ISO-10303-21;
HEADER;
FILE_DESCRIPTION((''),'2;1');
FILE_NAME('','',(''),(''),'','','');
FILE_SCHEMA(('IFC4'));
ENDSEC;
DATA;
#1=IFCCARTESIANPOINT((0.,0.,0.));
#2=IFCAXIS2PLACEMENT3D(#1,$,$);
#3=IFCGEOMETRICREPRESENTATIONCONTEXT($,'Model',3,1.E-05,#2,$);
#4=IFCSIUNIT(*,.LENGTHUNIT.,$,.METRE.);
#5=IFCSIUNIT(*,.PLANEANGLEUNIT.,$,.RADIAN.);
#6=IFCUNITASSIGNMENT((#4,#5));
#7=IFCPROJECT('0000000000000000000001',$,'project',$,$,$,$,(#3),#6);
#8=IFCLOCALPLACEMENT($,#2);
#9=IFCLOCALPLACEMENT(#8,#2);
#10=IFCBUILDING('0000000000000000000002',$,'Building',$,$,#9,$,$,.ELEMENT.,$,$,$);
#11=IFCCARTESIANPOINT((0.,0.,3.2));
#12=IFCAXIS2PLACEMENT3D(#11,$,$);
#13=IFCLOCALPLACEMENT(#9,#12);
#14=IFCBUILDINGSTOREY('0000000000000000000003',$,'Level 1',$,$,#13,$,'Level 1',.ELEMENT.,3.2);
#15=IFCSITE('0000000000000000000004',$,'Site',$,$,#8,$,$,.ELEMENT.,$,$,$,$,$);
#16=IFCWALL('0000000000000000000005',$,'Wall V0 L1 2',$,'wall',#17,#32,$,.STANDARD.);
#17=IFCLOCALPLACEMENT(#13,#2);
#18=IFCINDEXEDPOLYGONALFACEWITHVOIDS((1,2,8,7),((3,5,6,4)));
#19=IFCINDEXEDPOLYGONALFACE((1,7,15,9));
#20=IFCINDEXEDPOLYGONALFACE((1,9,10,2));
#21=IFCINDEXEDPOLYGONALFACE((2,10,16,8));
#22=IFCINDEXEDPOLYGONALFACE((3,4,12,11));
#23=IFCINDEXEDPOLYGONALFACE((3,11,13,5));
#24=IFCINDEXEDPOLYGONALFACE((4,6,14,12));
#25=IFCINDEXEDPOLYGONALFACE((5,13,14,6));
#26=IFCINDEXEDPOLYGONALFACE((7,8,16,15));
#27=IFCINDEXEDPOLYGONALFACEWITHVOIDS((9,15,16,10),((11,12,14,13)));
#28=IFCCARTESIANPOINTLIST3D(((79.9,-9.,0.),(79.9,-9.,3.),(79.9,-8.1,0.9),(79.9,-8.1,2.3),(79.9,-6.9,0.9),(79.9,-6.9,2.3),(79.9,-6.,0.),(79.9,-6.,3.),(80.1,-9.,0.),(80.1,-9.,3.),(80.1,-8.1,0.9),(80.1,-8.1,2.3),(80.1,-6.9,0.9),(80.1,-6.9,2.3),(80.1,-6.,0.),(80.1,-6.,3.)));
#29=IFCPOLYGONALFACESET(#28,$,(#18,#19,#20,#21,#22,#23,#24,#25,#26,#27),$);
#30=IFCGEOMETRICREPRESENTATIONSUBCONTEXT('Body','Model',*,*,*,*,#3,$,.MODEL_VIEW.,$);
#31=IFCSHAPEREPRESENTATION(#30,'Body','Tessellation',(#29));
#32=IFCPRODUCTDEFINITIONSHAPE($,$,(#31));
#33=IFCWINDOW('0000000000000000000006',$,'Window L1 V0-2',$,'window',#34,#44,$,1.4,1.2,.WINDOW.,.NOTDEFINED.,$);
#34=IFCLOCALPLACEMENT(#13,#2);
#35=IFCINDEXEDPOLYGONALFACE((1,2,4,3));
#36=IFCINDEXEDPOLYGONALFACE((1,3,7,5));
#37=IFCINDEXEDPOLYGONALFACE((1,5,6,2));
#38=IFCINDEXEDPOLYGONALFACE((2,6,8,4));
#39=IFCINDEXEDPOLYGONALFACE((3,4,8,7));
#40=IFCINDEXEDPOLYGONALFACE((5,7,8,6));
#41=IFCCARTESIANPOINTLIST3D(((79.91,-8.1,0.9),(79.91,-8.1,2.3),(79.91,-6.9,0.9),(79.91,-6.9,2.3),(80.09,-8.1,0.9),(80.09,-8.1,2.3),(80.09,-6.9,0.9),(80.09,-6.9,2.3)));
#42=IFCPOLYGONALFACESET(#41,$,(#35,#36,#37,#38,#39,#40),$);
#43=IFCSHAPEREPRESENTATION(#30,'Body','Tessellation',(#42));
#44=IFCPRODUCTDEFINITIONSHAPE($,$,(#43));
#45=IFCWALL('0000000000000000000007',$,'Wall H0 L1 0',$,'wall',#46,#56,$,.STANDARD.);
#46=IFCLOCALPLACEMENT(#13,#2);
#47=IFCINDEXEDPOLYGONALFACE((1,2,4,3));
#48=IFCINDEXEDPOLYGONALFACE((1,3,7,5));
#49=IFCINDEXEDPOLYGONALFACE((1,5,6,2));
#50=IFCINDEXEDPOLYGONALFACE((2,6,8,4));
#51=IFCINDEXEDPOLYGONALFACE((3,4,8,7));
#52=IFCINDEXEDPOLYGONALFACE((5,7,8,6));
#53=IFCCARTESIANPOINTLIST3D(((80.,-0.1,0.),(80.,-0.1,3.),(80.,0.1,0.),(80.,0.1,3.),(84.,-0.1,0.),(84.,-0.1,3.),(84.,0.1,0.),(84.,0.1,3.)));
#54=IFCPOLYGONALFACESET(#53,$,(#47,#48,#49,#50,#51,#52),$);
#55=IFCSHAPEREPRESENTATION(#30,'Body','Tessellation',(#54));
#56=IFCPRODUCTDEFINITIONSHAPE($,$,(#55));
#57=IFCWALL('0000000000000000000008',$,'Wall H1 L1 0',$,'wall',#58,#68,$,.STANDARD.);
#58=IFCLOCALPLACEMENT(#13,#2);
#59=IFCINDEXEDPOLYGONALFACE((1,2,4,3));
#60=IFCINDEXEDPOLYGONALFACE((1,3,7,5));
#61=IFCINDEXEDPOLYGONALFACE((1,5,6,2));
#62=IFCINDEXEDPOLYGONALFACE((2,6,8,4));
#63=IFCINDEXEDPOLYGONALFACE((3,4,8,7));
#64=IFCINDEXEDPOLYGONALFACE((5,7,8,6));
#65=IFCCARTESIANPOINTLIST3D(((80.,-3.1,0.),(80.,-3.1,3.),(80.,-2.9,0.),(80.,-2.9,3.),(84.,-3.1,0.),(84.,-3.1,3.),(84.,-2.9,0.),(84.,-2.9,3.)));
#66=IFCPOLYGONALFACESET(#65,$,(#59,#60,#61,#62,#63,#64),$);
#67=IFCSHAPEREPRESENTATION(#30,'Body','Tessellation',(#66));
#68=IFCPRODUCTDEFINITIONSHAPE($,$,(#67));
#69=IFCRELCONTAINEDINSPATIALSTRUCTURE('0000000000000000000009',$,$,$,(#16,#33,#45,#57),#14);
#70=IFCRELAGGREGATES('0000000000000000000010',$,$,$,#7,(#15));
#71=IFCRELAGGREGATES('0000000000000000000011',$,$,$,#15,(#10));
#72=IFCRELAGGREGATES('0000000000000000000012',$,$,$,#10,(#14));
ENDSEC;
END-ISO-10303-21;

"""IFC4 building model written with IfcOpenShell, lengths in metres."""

from ifc_helpers import new_model, si_unit, frame, frame_2d, origin, origin_2d, place, context, subcontext, project, spatial, rectangle, extrude, element, fill, save


model = new_model("IFC4")

# Units and contexts
model_context = context("Model", 3, precision=1e-05, world=origin())
body_context = subcontext(model_context, "Body", "Model", "MODEL_VIEW")
ifc_project = project(units=[si_unit("LENGTHUNIT", "METRE"), si_unit("PLANEANGLEUNIT", "RADIAN")], contexts=[model_context])

# Site, building, storey
site_placement = place(None, origin())
site = spatial("IfcSite", under=ifc_project, at=site_placement, Name="Site", CompositionType="ELEMENT")
building_placement = place(site_placement, origin())
building = spatial("IfcBuilding", under=site, at=building_placement, Name="Building", CompositionType="ELEMENT")
storey_placement = place(building_placement, frame((0.0, 0.0, 3.2)))
storey = spatial("IfcBuildingStorey", under=building, at=storey_placement, Name="Level 1", LongName="Level 1", CompositionType="ELEMENT", Elevation=3.2)

# Wall, opening, window
wall_1_placement = place(storey_placement, frame((80.0, -6.0, 0.0), z_axis=(0.0, 0.0, 1.0), x_axis=(0.0, -1.0, 0.0)))
wall_1 = element("IfcWall", 1, at=wall_1_placement, inside=storey, Name="Wall V0 L1 2", ObjectType="wall", PredefinedType="STANDARD", context=body_context, shape_type="SweptSolid", body=[
    extrude(rectangle(XDim=3.0, YDim=0.2, at=frame_2d((1.5, 0.0))), origin(), (0.0, 0.0, 1.0), 3.0),
])
opening_1_placement = place(storey_placement, frame((80.0, -7.5, 0.9), z_axis=(0.0, 0.0, 1.0), x_axis=(0.0, -1.0, 0.0)))
opening_1 = element("IfcOpeningElement", 2, at=opening_1_placement, cuts=wall_1, ObjectType="Opening", PredefinedType="OPENING", context=body_context, shape_type="SweptSolid", body=[
    extrude(rectangle(XDim=1.2, YDim=0.22, at=origin_2d()), origin(), (0.0, 0.0, 1.0), 1.4),
])
window_1_placement = place(storey_placement, frame((80.0, -7.5, 0.9), z_axis=(0.0, 0.0, 1.0), x_axis=(0.0, -1.0, 0.0)))
window_1 = element("IfcWindow", 3, at=window_1_placement, inside=storey, Name="Window L1 V0-2", ObjectType="window", OverallHeight=1.4, OverallWidth=1.2, PartitioningType="NOTDEFINED", PredefinedType="WINDOW", context=body_context, shape_type="SweptSolid", body=[
    extrude(rectangle(XDim=1.2, YDim=0.18, at=origin_2d()), origin(), (0.0, 0.0, 1.0), 1.4),
])
fill(opening_1, window_1)

# Walls
for number, where, z_axis, x_axis, name in (
    (4, (80.0, 0.0, 0.0), (0.0, 0.0, 1.0), (1.0, 0.0, 0.0), "Wall H0 L1 0"),
    (5, (80.0, -3.0, 0.0), (0.0, 0.0, 1.0), (1.0, 0.0, 0.0), "Wall H1 L1 0"),
):
    element("IfcWall", number, at=place(storey_placement, frame(where, z_axis=z_axis, x_axis=x_axis)), inside=storey, Name=name, ObjectType="wall", PredefinedType="STANDARD", context=body_context, shape_type="SweptSolid", body=[
        extrude(rectangle(XDim=4.0, YDim=0.2, at=frame_2d((2.0, 0.0))), origin(), (0.0, 0.0, 1.0), 3.0),
    ])

save(model, "model.ifc")
